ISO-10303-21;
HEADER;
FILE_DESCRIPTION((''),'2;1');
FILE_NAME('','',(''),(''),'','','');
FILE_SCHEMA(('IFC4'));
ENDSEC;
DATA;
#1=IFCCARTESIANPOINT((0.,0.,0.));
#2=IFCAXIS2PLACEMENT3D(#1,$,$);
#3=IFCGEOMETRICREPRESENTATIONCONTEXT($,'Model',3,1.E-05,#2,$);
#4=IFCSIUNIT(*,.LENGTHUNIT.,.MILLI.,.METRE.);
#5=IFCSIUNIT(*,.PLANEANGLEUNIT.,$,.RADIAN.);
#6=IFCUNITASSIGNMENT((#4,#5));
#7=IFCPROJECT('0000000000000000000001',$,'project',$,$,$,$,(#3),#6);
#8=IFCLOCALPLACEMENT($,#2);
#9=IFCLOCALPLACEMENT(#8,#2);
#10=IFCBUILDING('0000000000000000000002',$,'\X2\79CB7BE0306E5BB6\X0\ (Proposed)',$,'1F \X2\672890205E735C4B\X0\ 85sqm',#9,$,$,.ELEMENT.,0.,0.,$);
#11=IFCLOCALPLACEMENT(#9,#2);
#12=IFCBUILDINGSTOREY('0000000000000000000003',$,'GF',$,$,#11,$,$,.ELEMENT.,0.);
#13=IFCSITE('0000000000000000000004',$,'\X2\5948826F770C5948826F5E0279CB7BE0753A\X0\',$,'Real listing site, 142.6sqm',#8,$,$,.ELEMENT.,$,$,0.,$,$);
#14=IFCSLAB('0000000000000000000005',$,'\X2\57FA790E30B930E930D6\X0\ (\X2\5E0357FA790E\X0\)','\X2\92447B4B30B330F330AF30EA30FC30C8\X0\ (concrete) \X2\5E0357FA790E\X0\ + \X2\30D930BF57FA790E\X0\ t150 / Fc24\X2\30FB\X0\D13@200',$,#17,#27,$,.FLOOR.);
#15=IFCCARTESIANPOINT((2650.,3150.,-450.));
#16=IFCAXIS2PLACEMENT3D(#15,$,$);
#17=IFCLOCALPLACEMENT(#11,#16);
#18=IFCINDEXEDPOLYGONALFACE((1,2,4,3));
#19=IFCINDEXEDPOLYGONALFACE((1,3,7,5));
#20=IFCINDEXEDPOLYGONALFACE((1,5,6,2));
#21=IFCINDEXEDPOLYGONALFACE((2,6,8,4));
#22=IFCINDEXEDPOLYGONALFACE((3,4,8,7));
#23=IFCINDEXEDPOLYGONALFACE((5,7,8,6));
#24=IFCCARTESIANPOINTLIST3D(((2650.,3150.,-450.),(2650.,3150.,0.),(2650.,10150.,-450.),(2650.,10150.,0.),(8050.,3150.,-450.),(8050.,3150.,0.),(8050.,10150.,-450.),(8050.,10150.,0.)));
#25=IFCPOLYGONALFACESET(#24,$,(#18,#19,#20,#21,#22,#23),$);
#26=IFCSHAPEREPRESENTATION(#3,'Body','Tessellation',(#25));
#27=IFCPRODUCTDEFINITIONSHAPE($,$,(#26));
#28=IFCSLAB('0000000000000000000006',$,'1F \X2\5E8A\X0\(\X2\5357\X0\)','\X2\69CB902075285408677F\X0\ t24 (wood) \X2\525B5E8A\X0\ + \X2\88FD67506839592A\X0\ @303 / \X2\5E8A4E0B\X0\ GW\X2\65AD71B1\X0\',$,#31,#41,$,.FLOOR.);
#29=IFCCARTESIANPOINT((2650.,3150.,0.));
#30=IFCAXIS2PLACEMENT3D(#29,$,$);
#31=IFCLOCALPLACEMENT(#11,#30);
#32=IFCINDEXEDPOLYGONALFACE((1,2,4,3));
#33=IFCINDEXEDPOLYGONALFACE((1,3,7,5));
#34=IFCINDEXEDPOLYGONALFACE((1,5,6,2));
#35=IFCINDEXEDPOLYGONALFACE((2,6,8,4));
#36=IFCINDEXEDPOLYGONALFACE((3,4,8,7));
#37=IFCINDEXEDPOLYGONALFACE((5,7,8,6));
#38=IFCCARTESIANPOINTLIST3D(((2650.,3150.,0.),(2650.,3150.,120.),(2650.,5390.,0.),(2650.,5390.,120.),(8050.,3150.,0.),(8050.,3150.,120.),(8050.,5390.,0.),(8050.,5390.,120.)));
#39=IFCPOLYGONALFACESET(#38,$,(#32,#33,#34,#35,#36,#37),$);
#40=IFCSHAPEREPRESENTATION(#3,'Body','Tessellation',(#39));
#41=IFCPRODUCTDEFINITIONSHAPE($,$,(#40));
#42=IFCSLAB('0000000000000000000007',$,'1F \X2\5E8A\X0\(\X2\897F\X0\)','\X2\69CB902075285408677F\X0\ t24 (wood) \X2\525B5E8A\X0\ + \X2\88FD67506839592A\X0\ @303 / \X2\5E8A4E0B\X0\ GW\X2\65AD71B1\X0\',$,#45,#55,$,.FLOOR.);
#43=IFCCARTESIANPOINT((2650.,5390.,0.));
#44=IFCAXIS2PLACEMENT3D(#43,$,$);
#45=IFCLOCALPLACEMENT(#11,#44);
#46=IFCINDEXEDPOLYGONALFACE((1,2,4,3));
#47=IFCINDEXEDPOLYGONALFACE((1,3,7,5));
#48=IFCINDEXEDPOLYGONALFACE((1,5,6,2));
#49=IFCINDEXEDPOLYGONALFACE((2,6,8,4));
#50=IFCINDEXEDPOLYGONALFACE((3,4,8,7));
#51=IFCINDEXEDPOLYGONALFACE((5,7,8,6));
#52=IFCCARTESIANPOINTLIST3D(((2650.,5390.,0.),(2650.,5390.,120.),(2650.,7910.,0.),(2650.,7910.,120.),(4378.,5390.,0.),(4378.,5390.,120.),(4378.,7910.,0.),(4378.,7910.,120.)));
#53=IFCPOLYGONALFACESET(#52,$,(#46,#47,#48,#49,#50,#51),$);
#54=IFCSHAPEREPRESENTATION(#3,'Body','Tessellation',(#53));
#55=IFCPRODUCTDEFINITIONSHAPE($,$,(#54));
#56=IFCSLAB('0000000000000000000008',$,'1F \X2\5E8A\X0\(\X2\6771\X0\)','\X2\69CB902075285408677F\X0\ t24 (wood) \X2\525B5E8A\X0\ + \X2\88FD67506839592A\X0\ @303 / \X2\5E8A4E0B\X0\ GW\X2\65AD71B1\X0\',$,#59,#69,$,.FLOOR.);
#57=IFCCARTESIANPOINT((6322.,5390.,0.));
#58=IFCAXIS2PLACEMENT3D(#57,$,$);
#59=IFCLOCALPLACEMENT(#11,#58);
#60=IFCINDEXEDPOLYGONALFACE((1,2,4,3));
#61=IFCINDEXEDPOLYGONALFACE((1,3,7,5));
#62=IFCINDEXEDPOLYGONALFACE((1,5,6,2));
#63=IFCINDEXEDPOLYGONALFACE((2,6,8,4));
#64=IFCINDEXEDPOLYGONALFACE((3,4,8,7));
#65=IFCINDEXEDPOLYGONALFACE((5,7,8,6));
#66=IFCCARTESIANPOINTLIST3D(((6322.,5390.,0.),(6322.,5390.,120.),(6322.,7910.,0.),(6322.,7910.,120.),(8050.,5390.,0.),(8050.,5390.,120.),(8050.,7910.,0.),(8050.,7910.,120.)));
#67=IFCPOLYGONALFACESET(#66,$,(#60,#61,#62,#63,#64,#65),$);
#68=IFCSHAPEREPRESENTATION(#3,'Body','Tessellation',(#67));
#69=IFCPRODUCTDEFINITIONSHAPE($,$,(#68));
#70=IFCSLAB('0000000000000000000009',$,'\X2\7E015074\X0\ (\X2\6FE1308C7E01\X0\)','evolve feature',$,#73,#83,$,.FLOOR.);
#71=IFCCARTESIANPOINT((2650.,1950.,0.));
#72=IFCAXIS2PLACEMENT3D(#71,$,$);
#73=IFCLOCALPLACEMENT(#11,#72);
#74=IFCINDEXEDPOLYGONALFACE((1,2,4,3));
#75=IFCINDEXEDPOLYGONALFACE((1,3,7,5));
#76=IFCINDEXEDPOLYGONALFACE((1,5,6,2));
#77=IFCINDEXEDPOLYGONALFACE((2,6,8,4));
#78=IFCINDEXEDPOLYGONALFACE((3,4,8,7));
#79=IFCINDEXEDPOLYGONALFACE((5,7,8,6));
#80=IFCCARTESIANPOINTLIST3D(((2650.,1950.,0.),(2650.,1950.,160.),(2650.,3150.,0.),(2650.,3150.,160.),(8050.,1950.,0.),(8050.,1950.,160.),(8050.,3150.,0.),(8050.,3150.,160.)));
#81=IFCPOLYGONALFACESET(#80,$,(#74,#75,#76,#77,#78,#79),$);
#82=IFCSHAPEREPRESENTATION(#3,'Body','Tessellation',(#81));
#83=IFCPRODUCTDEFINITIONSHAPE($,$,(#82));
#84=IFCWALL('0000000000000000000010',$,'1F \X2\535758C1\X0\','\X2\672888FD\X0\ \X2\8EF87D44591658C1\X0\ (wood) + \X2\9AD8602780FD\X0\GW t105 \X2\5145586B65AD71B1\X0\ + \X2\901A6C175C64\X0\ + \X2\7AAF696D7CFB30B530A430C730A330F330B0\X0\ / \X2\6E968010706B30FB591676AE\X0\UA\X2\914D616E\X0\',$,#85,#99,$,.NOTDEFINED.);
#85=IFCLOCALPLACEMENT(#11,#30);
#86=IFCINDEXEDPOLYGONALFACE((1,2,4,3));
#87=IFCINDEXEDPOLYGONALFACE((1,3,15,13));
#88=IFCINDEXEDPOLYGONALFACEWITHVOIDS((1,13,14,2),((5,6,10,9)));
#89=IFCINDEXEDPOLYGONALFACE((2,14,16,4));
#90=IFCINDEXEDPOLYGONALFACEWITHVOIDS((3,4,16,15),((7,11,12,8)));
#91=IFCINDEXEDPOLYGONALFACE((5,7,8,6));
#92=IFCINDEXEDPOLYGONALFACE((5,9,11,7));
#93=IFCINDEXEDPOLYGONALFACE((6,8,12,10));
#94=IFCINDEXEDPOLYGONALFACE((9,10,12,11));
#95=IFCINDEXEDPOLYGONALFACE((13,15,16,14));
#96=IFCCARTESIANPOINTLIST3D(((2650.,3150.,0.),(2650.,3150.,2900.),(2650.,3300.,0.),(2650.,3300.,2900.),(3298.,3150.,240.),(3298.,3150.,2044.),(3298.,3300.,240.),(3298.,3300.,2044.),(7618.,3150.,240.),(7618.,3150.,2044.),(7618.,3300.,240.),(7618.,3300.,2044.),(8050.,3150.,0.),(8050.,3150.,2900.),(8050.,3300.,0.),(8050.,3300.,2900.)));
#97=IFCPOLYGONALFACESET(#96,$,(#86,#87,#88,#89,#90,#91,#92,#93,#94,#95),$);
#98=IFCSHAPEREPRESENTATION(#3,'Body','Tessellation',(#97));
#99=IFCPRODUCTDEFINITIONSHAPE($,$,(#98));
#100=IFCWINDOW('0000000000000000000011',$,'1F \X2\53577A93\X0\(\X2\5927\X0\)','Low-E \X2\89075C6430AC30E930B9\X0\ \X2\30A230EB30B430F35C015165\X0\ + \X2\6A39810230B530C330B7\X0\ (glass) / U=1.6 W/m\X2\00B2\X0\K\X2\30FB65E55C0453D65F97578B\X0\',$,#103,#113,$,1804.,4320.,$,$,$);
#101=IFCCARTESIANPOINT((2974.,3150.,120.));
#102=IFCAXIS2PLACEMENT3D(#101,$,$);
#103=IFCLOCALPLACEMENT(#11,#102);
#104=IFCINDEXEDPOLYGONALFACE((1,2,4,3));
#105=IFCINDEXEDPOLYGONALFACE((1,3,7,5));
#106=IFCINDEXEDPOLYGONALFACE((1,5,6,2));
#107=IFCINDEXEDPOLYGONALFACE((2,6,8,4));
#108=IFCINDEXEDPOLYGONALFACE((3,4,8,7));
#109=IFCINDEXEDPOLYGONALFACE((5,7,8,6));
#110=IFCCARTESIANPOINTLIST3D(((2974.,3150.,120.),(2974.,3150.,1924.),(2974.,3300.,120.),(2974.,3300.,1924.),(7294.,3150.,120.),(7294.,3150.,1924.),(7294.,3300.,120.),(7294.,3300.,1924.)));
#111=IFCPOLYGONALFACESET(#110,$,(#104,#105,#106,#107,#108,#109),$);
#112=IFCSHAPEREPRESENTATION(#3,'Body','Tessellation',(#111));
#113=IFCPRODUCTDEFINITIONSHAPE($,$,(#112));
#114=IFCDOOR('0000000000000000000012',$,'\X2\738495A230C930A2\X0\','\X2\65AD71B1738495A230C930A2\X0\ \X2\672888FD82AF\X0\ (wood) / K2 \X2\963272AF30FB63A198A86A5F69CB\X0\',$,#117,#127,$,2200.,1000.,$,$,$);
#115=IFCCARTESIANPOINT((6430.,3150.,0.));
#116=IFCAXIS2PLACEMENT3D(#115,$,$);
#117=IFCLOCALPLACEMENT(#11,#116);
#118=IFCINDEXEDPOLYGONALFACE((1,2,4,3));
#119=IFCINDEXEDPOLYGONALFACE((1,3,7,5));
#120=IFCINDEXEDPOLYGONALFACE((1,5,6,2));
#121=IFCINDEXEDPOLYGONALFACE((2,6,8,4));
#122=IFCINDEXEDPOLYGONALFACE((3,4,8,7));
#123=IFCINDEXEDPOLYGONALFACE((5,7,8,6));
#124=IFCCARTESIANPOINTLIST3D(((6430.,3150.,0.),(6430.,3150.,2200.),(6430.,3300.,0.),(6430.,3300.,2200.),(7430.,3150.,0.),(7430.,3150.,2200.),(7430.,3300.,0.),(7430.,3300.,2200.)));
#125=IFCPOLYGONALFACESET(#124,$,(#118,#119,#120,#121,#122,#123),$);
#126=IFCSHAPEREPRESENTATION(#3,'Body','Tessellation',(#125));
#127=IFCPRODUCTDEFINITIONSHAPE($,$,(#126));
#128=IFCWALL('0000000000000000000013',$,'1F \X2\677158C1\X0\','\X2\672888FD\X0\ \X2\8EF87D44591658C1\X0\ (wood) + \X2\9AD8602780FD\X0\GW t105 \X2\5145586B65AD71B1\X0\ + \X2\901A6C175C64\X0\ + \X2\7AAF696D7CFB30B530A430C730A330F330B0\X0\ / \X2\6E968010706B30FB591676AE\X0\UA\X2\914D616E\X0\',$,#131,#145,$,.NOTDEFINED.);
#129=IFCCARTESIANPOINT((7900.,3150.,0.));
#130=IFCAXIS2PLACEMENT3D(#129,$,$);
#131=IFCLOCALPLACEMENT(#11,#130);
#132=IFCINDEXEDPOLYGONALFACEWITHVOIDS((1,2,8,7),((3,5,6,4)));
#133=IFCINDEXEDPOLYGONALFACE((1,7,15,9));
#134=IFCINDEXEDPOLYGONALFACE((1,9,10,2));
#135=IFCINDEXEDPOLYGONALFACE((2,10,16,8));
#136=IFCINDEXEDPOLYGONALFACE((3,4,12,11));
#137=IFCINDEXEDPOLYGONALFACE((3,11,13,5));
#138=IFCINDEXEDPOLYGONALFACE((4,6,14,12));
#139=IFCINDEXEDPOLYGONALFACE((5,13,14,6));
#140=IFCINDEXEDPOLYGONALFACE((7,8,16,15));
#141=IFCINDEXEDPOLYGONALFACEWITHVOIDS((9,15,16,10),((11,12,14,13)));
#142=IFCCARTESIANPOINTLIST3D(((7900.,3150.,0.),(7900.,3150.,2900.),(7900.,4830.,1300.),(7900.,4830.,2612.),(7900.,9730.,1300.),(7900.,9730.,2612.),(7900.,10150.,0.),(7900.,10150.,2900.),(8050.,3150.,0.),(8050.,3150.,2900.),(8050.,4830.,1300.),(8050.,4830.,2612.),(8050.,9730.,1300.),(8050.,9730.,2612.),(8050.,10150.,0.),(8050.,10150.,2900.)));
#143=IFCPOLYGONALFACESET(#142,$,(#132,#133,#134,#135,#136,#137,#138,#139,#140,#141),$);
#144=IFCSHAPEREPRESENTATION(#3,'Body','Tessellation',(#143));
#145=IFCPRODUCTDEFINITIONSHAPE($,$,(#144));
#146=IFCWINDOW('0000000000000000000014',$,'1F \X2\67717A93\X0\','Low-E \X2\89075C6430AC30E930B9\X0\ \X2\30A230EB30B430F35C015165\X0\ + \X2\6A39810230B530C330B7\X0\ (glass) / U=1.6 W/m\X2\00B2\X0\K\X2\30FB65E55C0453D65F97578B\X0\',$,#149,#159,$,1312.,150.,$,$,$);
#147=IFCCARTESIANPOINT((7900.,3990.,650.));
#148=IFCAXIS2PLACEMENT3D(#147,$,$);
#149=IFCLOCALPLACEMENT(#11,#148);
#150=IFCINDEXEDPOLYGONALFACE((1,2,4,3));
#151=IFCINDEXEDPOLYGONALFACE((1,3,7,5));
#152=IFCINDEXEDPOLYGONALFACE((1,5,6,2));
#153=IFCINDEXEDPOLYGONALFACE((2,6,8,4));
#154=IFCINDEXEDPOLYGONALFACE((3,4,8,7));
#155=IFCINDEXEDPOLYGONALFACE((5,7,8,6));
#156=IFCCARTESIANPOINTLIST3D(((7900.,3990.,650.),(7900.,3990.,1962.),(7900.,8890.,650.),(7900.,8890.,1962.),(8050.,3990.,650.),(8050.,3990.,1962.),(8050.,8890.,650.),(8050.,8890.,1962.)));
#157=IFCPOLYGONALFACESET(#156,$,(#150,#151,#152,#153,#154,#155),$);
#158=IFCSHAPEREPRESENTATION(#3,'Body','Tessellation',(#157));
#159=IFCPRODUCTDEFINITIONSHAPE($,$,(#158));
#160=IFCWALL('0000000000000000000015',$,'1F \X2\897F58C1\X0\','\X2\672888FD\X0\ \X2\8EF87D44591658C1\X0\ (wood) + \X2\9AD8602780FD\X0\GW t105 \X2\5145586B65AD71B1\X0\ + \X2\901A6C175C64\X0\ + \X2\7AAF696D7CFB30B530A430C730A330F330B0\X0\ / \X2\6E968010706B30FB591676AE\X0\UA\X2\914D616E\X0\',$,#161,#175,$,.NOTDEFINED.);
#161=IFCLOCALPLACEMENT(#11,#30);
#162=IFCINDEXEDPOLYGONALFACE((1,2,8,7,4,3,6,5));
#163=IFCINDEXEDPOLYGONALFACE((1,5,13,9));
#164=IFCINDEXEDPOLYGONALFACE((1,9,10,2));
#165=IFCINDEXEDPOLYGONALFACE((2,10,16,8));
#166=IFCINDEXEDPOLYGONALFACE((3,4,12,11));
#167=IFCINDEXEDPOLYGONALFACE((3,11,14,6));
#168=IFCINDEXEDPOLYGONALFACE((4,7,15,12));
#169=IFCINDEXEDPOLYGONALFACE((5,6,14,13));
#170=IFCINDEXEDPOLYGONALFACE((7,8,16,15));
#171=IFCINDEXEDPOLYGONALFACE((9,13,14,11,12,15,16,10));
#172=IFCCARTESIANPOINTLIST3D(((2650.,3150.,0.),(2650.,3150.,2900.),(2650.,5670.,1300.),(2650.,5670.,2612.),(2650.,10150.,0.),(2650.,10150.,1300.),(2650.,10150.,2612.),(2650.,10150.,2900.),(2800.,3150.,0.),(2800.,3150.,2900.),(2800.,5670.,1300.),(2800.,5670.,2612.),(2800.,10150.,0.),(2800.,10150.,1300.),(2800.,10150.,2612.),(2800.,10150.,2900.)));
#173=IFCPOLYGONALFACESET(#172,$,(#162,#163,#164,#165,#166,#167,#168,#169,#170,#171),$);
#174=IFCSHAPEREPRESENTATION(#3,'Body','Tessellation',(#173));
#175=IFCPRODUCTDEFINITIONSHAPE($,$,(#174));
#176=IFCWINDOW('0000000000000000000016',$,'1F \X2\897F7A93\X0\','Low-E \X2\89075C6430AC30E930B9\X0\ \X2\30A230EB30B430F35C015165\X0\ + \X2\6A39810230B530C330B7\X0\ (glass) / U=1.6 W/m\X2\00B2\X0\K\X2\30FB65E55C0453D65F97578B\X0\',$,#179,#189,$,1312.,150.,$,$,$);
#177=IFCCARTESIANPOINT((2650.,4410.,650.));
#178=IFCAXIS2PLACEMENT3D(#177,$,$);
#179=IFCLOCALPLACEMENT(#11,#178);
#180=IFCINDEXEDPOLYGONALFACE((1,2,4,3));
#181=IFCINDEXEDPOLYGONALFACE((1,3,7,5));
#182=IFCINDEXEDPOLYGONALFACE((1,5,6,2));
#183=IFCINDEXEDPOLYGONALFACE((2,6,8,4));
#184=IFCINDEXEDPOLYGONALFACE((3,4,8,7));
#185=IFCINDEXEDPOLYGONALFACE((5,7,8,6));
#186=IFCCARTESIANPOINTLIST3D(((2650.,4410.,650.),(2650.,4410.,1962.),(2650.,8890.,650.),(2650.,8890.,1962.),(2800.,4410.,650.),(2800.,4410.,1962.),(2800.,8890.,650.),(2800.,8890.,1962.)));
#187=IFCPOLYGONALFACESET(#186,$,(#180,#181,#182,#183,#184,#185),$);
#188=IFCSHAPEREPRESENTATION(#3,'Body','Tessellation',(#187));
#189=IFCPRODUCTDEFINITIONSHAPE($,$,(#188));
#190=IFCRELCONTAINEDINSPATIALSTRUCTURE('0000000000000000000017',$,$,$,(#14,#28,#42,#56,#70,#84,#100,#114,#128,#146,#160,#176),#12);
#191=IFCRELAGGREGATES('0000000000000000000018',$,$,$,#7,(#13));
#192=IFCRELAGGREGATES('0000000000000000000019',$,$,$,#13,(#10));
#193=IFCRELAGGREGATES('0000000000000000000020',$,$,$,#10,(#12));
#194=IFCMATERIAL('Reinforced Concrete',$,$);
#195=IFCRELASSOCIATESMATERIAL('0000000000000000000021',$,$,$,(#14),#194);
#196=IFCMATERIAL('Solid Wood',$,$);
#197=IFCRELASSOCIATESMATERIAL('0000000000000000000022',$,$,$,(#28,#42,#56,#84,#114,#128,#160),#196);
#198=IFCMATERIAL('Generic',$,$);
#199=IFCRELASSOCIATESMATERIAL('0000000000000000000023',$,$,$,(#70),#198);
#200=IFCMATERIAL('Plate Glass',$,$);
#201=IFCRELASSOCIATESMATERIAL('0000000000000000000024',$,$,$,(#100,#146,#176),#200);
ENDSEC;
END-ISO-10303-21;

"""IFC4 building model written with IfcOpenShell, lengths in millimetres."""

from ifc_helpers import new_model, si_unit, frame, frame_2d, origin, place, context, project, spatial, rectangle, extrude, material, element, fill, save


model = new_model("IFC4")

# Units and contexts
model_context = context("Model", 3, precision=1e-05, world=origin())
ifc_project = project(units=[si_unit("LENGTHUNIT", "METRE", prefix="MILLI"), si_unit("PLANEANGLEUNIT", "RADIAN")], contexts=[model_context])

# Site, building, storey
site_placement = place(None, origin())
site = spatial("IfcSite", under=ifc_project, at=site_placement, Name="奈良県奈良市秋篠町", ObjectType="Real listing site, 142.6sqm", CompositionType="ELEMENT", RefElevation=0.0)
building_placement = place(site_placement, origin())
building = spatial("IfcBuilding", under=site, at=building_placement, Name="秋篠の家 (Proposed)", ObjectType="1F 木造平屋 85sqm", CompositionType="ELEMENT", ElevationOfRefHeight=0.0, ElevationOfTerrain=0.0)
storey_placement = place(building_placement, origin())
storey = spatial("IfcBuildingStorey", under=building, at=storey_placement, Name="GF", CompositionType="ELEMENT", Elevation=0.0)

# Slabs
ifc_material_1 = material(Name="Reinforced Concrete")
slab_1_placement = place(storey_placement, frame((2650.0, 3150.0, -450.0)))
element("IfcSlab", 1, at=slab_1_placement, inside=storey, material=ifc_material_1, Name="基礎スラブ (布基礎)", Description="鉄筋コンクリート (concrete) 布基礎 + ベタ基礎 t150 / Fc24・D13@200", PredefinedType="FLOOR", context=model_context, shape_type="SweptSolid", body=[
    extrude(rectangle(XDim=5400.0, YDim=7000.0, at=frame_2d((2700.0, 3500.0))), frame((2650.0, 3150.0, -450.0)), (0.0, 0.0, 1.0), 450.0),
])
ifc_material_2 = material(Name="Solid Wood")
slab_2_placement = place(storey_placement, frame((2650.0, 3150.0, 0.0)))
element("IfcSlab", 2, at=slab_2_placement, inside=storey, material=ifc_material_2, Name="1F 床(南)", Description="構造用合板 t24 (wood) 剛床 + 製材根太 @303 / 床下 GW断熱", PredefinedType="FLOOR", context=model_context, shape_type="SweptSolid", body=[
    extrude(rectangle(XDim=5400.0, YDim=2240.0, at=frame_2d((2700.0, 1120.0))), frame((2650.0, 3150.0, 0.0)), (0.0, 0.0, 1.0), 120.0),
])
slab_3_placement = place(storey_placement, frame((2650.0, 5390.0, 0.0)))
element("IfcSlab", 3, at=slab_3_placement, inside=storey, material=ifc_material_2, Name="1F 床(西)", Description="構造用合板 t24 (wood) 剛床 + 製材根太 @303 / 床下 GW断熱", PredefinedType="FLOOR", context=model_context, shape_type="SweptSolid", body=[
    extrude(rectangle(XDim=1728.0, YDim=2520.0, at=frame_2d((864.0, 1260.0))), frame((2650.0, 5390.0, 0.0)), (0.0, 0.0, 1.0), 120.0),
])
slab_4_placement = place(storey_placement, frame((6322.0, 5390.0, 0.0)))
element("IfcSlab", 4, at=slab_4_placement, inside=storey, material=ifc_material_2, Name="1F 床(東)", Description="構造用合板 t24 (wood) 剛床 + 製材根太 @303 / 床下 GW断熱", PredefinedType="FLOOR", context=model_context, shape_type="SweptSolid", body=[
    extrude(rectangle(XDim=1728.0, YDim=2520.0, at=frame_2d((864.0, 1260.0))), frame((6322.0, 5390.0, 0.0)), (0.0, 0.0, 1.0), 120.0),
])
ifc_material_3 = material(Name="Generic")
slab_5_placement = place(storey_placement, frame((2650.0, 1950.0, 0.0)))
element("IfcSlab", 5, at=slab_5_placement, inside=storey, material=ifc_material_3, Name="縁側 (濡れ縁)", Description="evolve feature", PredefinedType="FLOOR", context=model_context, shape_type="SweptSolid", body=[
    extrude(rectangle(XDim=5400.0, YDim=1200.0, at=frame_2d((2700.0, 600.0))), frame((2650.0, 1950.0, 0.0)), (0.0, 0.0, 1.0), 160.0),
])

# Wall, openings, window, door
wall_1_placement = place(storey_placement, frame((2650.0, 3150.0, 0.0)))
wall_1 = element("IfcWall", 6, at=wall_1_placement, inside=storey, material=ifc_material_2, Name="1F 南壁", Description="木製 軸組外壁 (wood) + 高性能GW t105 充填断熱 + 通気層 + 窯業系サイディング / 準耐火・外皮UA配慮", PredefinedType="NOTDEFINED", context=model_context, shape_type="SweptSolid", body=[
    extrude(rectangle(XDim=5400.0, YDim=150.0, at=frame_2d((2700.0, 75.0))), frame((2650.0, 3150.0, 0.0)), (0.0, 0.0, 1.0), 2900.0),
])
opening_1_placement = place(storey_placement, frame((2974.0, 3150.0, 120.0)))
opening_1 = element("IfcOpeningElement", 7, at=opening_1_placement, cuts=wall_1, PredefinedType="NOTDEFINED", context=model_context, shape_type="SweptSolid", body=[
    extrude(rectangle(XDim=4320.0, YDim=150.0, at=frame_2d((2160.0, 75.0))), frame((2974.0, 3150.0, 120.0)), (0.0, 0.0, 1.0), 1804.0),
])
opening_2_placement = place(storey_placement, frame((6430.0, 3150.0, 0.0)))
opening_2 = element("IfcOpeningElement", 8, at=opening_2_placement, cuts=wall_1, PredefinedType="NOTDEFINED", context=model_context, shape_type="SweptSolid", body=[
    extrude(rectangle(XDim=1000.0, YDim=150.0, at=frame_2d((500.0, 75.0))), frame((6430.0, 3150.0, 0.0)), (0.0, 0.0, 1.0), 2200.0),
])
ifc_material_4 = material(Name="Plate Glass")
window_1_placement = place(storey_placement, frame((2974.0, 3150.0, 120.0)))
window_1 = element("IfcWindow", 9, at=window_1_placement, inside=storey, material=ifc_material_4, Name="1F 南窓(大)", Description="Low-E 複層ガラス アルゴン封入 + 樹脂サッシ (glass) / U=1.6 W/m²K・日射取得型", OverallHeight=1804.0, OverallWidth=4320.0, context=model_context, shape_type="SweptSolid", body=[
    extrude(rectangle(XDim=4320.0, YDim=150.0, at=frame_2d((2160.0, 75.0))), frame((2974.0, 3150.0, 120.0)), (0.0, 0.0, 1.0), 1804.0),
])
fill(opening_1, window_1)
door_placement = place(storey_placement, frame((6430.0, 3150.0, 0.0)))
door = element("IfcDoor", 10, at=door_placement, inside=storey, material=ifc_material_2, Name="玄関ドア", Description="断熱玄関ドア 木製芯 (wood) / K2 防犯・採風機構", OverallHeight=2200.0, OverallWidth=1000.0, context=model_context, shape_type="SweptSolid", body=[
    extrude(rectangle(XDim=1000.0, YDim=150.0, at=frame_2d((500.0, 75.0))), frame((6430.0, 3150.0, 0.0)), (0.0, 0.0, 1.0), 2200.0),
])
fill(opening_2, door)

# Walls, openings, windows
wall_2_placement = place(storey_placement, frame((7900.0, 3150.0, 0.0)))
wall_2 = element("IfcWall", 11, at=wall_2_placement, inside=storey, material=ifc_material_2, Name="1F 東壁", Description="木製 軸組外壁 (wood) + 高性能GW t105 充填断熱 + 通気層 + 窯業系サイディング / 準耐火・外皮UA配慮", PredefinedType="NOTDEFINED", context=model_context, shape_type="SweptSolid", body=[
    extrude(rectangle(XDim=150.0, YDim=7000.0, at=frame_2d((75.0, 3500.0))), frame((7900.0, 3150.0, 0.0)), (0.0, 0.0, 1.0), 2900.0),
])
opening_3_placement = place(storey_placement, frame((7900.0, 3990.0, 650.0)))
opening_3 = element("IfcOpeningElement", 12, at=opening_3_placement, cuts=wall_2, PredefinedType="NOTDEFINED", context=model_context, shape_type="SweptSolid", body=[
    extrude(rectangle(XDim=150.0, YDim=4900.0, at=frame_2d((75.0, 2450.0))), frame((7900.0, 3990.0, 650.0)), (0.0, 0.0, 1.0), 1312.0),
])
window_2_placement = place(storey_placement, frame((7900.0, 3990.0, 650.0)))
window_2 = element("IfcWindow", 13, at=window_2_placement, inside=storey, material=ifc_material_4, Name="1F 東窓", Description="Low-E 複層ガラス アルゴン封入 + 樹脂サッシ (glass) / U=1.6 W/m²K・日射取得型", OverallHeight=1312.0, OverallWidth=150.0, context=model_context, shape_type="SweptSolid", body=[
    extrude(rectangle(XDim=150.0, YDim=4900.0, at=frame_2d((75.0, 2450.0))), frame((7900.0, 3990.0, 650.0)), (0.0, 0.0, 1.0), 1312.0),
])
fill(opening_3, window_2)
wall_3_placement = place(storey_placement, frame((2650.0, 3150.0, 0.0)))
wall_3 = element("IfcWall", 14, at=wall_3_placement, inside=storey, material=ifc_material_2, Name="1F 西壁", Description="木製 軸組外壁 (wood) + 高性能GW t105 充填断熱 + 通気層 + 窯業系サイディング / 準耐火・外皮UA配慮", PredefinedType="NOTDEFINED", context=model_context, shape_type="SweptSolid", body=[
    extrude(rectangle(XDim=150.0, YDim=7000.0, at=frame_2d((75.0, 3500.0))), frame((2650.0, 3150.0, 0.0)), (0.0, 0.0, 1.0), 2900.0),
])
opening_4_placement = place(storey_placement, frame((2650.0, 4410.0, 650.0)))
opening_4 = element("IfcOpeningElement", 15, at=opening_4_placement, cuts=wall_3, PredefinedType="NOTDEFINED", context=model_context, shape_type="SweptSolid", body=[
    extrude(rectangle(XDim=150.0, YDim=4480.0, at=frame_2d((75.0, 2240.0))), frame((2650.0, 4410.0, 650.0)), (0.0, 0.0, 1.0), 1312.0),
])
window_3_placement = place(storey_placement, frame((2650.0, 4410.0, 650.0)))
window_3 = element("IfcWindow", 16, at=window_3_placement, inside=storey, material=ifc_material_4, Name="1F 西窓", Description="Low-E 複層ガラス アルゴン封入 + 樹脂サッシ (glass) / U=1.6 W/m²K・日射取得型", OverallHeight=1312.0, OverallWidth=150.0, context=model_context, shape_type="SweptSolid", body=[
    extrude(rectangle(XDim=150.0, YDim=4480.0, at=frame_2d((75.0, 2240.0))), frame((2650.0, 4410.0, 650.0)), (0.0, 0.0, 1.0), 1312.0),
])
fill(opening_4, window_3)

save(model, "model.ifc")
